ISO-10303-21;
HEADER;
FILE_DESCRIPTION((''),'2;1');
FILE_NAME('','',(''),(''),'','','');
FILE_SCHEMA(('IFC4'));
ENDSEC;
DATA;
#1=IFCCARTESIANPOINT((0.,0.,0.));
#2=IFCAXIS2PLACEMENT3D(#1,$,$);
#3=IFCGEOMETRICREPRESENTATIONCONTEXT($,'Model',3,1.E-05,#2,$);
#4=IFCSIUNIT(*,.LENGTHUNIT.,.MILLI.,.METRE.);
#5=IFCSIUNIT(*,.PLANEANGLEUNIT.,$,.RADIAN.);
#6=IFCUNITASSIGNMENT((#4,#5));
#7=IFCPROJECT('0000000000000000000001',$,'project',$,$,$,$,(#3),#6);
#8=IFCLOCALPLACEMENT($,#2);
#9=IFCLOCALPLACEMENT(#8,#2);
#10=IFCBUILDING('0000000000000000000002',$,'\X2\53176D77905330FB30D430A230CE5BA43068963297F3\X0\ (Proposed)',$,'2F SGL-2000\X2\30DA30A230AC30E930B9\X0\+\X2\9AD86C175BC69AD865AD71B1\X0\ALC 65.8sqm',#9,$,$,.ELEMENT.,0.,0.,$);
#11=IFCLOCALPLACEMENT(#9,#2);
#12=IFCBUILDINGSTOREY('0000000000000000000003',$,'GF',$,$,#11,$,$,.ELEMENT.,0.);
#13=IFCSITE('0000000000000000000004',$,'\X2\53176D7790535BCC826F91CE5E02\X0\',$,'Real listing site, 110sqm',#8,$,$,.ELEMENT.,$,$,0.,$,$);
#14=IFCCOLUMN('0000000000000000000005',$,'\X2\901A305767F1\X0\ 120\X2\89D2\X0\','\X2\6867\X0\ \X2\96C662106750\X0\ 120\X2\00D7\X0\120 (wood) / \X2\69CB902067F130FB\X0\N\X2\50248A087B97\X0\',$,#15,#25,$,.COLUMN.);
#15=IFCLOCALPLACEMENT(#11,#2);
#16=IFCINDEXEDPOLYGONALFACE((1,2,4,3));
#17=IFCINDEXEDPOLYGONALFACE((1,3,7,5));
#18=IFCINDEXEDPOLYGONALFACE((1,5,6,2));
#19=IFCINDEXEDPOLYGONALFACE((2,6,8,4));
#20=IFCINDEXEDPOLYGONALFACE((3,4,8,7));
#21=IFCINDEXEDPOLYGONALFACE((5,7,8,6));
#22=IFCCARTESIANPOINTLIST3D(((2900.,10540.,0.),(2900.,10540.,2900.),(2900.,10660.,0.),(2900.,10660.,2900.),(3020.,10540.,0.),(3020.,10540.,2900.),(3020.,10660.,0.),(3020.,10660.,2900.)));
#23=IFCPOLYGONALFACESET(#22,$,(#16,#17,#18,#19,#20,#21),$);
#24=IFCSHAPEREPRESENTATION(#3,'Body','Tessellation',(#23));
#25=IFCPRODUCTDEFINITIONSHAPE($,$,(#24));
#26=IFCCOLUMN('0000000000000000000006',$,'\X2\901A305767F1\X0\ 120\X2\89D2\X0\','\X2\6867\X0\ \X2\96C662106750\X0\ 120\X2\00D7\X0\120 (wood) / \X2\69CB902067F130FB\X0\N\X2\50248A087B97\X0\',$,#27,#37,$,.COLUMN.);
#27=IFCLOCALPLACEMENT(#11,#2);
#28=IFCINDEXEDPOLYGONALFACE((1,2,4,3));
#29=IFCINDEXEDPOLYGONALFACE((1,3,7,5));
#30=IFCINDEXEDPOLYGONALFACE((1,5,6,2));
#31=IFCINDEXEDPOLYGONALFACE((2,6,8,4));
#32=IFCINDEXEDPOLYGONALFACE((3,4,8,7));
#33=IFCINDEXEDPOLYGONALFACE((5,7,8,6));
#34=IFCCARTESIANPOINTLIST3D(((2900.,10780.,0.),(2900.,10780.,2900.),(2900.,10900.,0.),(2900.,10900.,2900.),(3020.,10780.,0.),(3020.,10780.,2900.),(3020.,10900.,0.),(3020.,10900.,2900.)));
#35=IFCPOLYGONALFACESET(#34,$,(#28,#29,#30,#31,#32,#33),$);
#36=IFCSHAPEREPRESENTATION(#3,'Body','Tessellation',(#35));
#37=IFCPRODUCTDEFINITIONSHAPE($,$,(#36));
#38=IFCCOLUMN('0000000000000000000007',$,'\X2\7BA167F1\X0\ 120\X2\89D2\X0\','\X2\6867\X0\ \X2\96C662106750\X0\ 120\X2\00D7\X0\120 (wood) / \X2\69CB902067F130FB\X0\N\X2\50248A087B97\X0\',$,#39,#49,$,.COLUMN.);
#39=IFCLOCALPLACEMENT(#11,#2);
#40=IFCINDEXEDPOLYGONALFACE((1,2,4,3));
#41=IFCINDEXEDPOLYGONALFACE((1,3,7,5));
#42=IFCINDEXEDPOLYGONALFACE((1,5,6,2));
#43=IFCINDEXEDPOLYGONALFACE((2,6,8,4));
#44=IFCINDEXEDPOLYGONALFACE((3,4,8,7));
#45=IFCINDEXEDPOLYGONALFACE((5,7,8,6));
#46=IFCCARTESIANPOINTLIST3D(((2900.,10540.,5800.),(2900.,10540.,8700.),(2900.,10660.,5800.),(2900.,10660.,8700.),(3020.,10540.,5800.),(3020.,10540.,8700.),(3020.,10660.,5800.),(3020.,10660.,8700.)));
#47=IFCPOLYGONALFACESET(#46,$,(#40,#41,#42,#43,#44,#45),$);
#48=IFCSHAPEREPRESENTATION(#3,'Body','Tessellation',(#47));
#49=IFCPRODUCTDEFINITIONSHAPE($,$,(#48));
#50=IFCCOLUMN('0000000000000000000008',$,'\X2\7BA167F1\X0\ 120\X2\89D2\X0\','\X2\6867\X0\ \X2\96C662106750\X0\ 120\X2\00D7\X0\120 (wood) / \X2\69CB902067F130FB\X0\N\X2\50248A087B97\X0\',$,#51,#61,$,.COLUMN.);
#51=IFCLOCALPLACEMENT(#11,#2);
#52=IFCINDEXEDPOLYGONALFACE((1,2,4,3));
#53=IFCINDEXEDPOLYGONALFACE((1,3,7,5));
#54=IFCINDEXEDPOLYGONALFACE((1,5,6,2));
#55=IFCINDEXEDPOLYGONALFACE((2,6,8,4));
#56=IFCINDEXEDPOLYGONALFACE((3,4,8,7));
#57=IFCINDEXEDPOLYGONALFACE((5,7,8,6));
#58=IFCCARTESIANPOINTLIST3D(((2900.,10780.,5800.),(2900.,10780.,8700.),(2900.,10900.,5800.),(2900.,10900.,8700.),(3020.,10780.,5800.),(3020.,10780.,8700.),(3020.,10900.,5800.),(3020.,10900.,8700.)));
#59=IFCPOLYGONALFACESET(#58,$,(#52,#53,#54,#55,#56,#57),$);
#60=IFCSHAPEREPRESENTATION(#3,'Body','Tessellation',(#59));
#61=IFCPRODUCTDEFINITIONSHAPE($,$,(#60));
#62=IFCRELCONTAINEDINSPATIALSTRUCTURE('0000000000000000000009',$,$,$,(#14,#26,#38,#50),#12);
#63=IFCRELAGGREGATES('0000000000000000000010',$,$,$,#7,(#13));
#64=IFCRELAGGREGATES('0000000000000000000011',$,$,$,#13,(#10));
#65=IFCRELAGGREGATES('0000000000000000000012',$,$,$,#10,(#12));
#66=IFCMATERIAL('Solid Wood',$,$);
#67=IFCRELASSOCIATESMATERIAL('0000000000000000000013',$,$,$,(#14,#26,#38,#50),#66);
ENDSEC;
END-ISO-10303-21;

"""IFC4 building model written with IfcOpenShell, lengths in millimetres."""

from ifc_helpers import new_model, si_unit, frame, frame_2d, origin, place, context, project, spatial, rectangle, extrude, material, element, save


model = new_model("IFC4")

# Units and contexts
model_context = context("Model", 3, precision=1e-05, world=origin())
ifc_project = project(units=[si_unit("LENGTHUNIT", "METRE", prefix="MILLI"), si_unit("PLANEANGLEUNIT", "RADIAN")], contexts=[model_context])

# Site, building, storey
site_placement = place(None, origin())
site = spatial("IfcSite", under=ifc_project, at=site_placement, Name="北海道富良野市", ObjectType="Real listing site, 110sqm", CompositionType="ELEMENT", RefElevation=0.0)
building_placement = place(site_placement, origin())
building = spatial("IfcBuilding", under=site, at=building_placement, Name="北海道・ピアノ室と防音 (Proposed)", ObjectType="2F SGL-2000ペアガラス+高気密高断熱ALC 65.8sqm", CompositionType="ELEMENT", ElevationOfRefHeight=0.0, ElevationOfTerrain=0.0)
storey_placement = place(building_placement, origin())
storey = spatial("IfcBuildingStorey", under=building, at=storey_placement, Name="GF", CompositionType="ELEMENT", Elevation=0.0)

# Columns
ifc_material_1 = material(Name="Solid Wood")
column_1_placement = place(storey_placement, frame((1450.0, 5270.0, 0.0)))
element("IfcColumn", 1, at=column_1_placement, inside=storey, material=ifc_material_1, Name="通し柱 120角", Description="桧 集成材 120×120 (wood) / 構造柱・N値計算", PredefinedType="COLUMN", context=model_context, shape_type="SweptSolid", body=[
    extrude(rectangle(XDim=120.0, YDim=120.0, at=frame_2d((60.0, 60.0))), frame((1450.0, 5270.0, 0.0)), (0.0, 0.0, 1.0), 2900.0),
])
column_2_placement = place(storey_placement, frame((1450.0, 5390.0, 0.0)))
element("IfcColumn", 2, at=column_2_placement, inside=storey, material=ifc_material_1, Name="通し柱 120角", Description="桧 集成材 120×120 (wood) / 構造柱・N値計算", PredefinedType="COLUMN", context=model_context, shape_type="SweptSolid", body=[
    extrude(rectangle(XDim=120.0, YDim=120.0, at=frame_2d((60.0, 60.0))), frame((1450.0, 5390.0, 0.0)), (0.0, 0.0, 1.0), 2900.0),
])
column_3_placement = place(storey_placement, frame((1450.0, 5270.0, 2900.0)))
element("IfcColumn", 3, at=column_3_placement, inside=storey, material=ifc_material_1, Name="管柱 120角", Description="桧 集成材 120×120 (wood) / 構造柱・N値計算", PredefinedType="COLUMN", context=model_context, shape_type="SweptSolid", body=[
    extrude(rectangle(XDim=120.0, YDim=120.0, at=frame_2d((60.0, 60.0))), frame((1450.0, 5270.0, 2900.0)), (0.0, 0.0, 1.0), 2900.0),
])
column_4_placement = place(storey_placement, frame((1450.0, 5390.0, 2900.0)))
element("IfcColumn", 4, at=column_4_placement, inside=storey, material=ifc_material_1, Name="管柱 120角", Description="桧 集成材 120×120 (wood) / 構造柱・N値計算", PredefinedType="COLUMN", context=model_context, shape_type="SweptSolid", body=[
    extrude(rectangle(XDim=120.0, YDim=120.0, at=frame_2d((60.0, 60.0))), frame((1450.0, 5390.0, 2900.0)), (0.0, 0.0, 1.0), 2900.0),
])

save(model, "model.ifc")
